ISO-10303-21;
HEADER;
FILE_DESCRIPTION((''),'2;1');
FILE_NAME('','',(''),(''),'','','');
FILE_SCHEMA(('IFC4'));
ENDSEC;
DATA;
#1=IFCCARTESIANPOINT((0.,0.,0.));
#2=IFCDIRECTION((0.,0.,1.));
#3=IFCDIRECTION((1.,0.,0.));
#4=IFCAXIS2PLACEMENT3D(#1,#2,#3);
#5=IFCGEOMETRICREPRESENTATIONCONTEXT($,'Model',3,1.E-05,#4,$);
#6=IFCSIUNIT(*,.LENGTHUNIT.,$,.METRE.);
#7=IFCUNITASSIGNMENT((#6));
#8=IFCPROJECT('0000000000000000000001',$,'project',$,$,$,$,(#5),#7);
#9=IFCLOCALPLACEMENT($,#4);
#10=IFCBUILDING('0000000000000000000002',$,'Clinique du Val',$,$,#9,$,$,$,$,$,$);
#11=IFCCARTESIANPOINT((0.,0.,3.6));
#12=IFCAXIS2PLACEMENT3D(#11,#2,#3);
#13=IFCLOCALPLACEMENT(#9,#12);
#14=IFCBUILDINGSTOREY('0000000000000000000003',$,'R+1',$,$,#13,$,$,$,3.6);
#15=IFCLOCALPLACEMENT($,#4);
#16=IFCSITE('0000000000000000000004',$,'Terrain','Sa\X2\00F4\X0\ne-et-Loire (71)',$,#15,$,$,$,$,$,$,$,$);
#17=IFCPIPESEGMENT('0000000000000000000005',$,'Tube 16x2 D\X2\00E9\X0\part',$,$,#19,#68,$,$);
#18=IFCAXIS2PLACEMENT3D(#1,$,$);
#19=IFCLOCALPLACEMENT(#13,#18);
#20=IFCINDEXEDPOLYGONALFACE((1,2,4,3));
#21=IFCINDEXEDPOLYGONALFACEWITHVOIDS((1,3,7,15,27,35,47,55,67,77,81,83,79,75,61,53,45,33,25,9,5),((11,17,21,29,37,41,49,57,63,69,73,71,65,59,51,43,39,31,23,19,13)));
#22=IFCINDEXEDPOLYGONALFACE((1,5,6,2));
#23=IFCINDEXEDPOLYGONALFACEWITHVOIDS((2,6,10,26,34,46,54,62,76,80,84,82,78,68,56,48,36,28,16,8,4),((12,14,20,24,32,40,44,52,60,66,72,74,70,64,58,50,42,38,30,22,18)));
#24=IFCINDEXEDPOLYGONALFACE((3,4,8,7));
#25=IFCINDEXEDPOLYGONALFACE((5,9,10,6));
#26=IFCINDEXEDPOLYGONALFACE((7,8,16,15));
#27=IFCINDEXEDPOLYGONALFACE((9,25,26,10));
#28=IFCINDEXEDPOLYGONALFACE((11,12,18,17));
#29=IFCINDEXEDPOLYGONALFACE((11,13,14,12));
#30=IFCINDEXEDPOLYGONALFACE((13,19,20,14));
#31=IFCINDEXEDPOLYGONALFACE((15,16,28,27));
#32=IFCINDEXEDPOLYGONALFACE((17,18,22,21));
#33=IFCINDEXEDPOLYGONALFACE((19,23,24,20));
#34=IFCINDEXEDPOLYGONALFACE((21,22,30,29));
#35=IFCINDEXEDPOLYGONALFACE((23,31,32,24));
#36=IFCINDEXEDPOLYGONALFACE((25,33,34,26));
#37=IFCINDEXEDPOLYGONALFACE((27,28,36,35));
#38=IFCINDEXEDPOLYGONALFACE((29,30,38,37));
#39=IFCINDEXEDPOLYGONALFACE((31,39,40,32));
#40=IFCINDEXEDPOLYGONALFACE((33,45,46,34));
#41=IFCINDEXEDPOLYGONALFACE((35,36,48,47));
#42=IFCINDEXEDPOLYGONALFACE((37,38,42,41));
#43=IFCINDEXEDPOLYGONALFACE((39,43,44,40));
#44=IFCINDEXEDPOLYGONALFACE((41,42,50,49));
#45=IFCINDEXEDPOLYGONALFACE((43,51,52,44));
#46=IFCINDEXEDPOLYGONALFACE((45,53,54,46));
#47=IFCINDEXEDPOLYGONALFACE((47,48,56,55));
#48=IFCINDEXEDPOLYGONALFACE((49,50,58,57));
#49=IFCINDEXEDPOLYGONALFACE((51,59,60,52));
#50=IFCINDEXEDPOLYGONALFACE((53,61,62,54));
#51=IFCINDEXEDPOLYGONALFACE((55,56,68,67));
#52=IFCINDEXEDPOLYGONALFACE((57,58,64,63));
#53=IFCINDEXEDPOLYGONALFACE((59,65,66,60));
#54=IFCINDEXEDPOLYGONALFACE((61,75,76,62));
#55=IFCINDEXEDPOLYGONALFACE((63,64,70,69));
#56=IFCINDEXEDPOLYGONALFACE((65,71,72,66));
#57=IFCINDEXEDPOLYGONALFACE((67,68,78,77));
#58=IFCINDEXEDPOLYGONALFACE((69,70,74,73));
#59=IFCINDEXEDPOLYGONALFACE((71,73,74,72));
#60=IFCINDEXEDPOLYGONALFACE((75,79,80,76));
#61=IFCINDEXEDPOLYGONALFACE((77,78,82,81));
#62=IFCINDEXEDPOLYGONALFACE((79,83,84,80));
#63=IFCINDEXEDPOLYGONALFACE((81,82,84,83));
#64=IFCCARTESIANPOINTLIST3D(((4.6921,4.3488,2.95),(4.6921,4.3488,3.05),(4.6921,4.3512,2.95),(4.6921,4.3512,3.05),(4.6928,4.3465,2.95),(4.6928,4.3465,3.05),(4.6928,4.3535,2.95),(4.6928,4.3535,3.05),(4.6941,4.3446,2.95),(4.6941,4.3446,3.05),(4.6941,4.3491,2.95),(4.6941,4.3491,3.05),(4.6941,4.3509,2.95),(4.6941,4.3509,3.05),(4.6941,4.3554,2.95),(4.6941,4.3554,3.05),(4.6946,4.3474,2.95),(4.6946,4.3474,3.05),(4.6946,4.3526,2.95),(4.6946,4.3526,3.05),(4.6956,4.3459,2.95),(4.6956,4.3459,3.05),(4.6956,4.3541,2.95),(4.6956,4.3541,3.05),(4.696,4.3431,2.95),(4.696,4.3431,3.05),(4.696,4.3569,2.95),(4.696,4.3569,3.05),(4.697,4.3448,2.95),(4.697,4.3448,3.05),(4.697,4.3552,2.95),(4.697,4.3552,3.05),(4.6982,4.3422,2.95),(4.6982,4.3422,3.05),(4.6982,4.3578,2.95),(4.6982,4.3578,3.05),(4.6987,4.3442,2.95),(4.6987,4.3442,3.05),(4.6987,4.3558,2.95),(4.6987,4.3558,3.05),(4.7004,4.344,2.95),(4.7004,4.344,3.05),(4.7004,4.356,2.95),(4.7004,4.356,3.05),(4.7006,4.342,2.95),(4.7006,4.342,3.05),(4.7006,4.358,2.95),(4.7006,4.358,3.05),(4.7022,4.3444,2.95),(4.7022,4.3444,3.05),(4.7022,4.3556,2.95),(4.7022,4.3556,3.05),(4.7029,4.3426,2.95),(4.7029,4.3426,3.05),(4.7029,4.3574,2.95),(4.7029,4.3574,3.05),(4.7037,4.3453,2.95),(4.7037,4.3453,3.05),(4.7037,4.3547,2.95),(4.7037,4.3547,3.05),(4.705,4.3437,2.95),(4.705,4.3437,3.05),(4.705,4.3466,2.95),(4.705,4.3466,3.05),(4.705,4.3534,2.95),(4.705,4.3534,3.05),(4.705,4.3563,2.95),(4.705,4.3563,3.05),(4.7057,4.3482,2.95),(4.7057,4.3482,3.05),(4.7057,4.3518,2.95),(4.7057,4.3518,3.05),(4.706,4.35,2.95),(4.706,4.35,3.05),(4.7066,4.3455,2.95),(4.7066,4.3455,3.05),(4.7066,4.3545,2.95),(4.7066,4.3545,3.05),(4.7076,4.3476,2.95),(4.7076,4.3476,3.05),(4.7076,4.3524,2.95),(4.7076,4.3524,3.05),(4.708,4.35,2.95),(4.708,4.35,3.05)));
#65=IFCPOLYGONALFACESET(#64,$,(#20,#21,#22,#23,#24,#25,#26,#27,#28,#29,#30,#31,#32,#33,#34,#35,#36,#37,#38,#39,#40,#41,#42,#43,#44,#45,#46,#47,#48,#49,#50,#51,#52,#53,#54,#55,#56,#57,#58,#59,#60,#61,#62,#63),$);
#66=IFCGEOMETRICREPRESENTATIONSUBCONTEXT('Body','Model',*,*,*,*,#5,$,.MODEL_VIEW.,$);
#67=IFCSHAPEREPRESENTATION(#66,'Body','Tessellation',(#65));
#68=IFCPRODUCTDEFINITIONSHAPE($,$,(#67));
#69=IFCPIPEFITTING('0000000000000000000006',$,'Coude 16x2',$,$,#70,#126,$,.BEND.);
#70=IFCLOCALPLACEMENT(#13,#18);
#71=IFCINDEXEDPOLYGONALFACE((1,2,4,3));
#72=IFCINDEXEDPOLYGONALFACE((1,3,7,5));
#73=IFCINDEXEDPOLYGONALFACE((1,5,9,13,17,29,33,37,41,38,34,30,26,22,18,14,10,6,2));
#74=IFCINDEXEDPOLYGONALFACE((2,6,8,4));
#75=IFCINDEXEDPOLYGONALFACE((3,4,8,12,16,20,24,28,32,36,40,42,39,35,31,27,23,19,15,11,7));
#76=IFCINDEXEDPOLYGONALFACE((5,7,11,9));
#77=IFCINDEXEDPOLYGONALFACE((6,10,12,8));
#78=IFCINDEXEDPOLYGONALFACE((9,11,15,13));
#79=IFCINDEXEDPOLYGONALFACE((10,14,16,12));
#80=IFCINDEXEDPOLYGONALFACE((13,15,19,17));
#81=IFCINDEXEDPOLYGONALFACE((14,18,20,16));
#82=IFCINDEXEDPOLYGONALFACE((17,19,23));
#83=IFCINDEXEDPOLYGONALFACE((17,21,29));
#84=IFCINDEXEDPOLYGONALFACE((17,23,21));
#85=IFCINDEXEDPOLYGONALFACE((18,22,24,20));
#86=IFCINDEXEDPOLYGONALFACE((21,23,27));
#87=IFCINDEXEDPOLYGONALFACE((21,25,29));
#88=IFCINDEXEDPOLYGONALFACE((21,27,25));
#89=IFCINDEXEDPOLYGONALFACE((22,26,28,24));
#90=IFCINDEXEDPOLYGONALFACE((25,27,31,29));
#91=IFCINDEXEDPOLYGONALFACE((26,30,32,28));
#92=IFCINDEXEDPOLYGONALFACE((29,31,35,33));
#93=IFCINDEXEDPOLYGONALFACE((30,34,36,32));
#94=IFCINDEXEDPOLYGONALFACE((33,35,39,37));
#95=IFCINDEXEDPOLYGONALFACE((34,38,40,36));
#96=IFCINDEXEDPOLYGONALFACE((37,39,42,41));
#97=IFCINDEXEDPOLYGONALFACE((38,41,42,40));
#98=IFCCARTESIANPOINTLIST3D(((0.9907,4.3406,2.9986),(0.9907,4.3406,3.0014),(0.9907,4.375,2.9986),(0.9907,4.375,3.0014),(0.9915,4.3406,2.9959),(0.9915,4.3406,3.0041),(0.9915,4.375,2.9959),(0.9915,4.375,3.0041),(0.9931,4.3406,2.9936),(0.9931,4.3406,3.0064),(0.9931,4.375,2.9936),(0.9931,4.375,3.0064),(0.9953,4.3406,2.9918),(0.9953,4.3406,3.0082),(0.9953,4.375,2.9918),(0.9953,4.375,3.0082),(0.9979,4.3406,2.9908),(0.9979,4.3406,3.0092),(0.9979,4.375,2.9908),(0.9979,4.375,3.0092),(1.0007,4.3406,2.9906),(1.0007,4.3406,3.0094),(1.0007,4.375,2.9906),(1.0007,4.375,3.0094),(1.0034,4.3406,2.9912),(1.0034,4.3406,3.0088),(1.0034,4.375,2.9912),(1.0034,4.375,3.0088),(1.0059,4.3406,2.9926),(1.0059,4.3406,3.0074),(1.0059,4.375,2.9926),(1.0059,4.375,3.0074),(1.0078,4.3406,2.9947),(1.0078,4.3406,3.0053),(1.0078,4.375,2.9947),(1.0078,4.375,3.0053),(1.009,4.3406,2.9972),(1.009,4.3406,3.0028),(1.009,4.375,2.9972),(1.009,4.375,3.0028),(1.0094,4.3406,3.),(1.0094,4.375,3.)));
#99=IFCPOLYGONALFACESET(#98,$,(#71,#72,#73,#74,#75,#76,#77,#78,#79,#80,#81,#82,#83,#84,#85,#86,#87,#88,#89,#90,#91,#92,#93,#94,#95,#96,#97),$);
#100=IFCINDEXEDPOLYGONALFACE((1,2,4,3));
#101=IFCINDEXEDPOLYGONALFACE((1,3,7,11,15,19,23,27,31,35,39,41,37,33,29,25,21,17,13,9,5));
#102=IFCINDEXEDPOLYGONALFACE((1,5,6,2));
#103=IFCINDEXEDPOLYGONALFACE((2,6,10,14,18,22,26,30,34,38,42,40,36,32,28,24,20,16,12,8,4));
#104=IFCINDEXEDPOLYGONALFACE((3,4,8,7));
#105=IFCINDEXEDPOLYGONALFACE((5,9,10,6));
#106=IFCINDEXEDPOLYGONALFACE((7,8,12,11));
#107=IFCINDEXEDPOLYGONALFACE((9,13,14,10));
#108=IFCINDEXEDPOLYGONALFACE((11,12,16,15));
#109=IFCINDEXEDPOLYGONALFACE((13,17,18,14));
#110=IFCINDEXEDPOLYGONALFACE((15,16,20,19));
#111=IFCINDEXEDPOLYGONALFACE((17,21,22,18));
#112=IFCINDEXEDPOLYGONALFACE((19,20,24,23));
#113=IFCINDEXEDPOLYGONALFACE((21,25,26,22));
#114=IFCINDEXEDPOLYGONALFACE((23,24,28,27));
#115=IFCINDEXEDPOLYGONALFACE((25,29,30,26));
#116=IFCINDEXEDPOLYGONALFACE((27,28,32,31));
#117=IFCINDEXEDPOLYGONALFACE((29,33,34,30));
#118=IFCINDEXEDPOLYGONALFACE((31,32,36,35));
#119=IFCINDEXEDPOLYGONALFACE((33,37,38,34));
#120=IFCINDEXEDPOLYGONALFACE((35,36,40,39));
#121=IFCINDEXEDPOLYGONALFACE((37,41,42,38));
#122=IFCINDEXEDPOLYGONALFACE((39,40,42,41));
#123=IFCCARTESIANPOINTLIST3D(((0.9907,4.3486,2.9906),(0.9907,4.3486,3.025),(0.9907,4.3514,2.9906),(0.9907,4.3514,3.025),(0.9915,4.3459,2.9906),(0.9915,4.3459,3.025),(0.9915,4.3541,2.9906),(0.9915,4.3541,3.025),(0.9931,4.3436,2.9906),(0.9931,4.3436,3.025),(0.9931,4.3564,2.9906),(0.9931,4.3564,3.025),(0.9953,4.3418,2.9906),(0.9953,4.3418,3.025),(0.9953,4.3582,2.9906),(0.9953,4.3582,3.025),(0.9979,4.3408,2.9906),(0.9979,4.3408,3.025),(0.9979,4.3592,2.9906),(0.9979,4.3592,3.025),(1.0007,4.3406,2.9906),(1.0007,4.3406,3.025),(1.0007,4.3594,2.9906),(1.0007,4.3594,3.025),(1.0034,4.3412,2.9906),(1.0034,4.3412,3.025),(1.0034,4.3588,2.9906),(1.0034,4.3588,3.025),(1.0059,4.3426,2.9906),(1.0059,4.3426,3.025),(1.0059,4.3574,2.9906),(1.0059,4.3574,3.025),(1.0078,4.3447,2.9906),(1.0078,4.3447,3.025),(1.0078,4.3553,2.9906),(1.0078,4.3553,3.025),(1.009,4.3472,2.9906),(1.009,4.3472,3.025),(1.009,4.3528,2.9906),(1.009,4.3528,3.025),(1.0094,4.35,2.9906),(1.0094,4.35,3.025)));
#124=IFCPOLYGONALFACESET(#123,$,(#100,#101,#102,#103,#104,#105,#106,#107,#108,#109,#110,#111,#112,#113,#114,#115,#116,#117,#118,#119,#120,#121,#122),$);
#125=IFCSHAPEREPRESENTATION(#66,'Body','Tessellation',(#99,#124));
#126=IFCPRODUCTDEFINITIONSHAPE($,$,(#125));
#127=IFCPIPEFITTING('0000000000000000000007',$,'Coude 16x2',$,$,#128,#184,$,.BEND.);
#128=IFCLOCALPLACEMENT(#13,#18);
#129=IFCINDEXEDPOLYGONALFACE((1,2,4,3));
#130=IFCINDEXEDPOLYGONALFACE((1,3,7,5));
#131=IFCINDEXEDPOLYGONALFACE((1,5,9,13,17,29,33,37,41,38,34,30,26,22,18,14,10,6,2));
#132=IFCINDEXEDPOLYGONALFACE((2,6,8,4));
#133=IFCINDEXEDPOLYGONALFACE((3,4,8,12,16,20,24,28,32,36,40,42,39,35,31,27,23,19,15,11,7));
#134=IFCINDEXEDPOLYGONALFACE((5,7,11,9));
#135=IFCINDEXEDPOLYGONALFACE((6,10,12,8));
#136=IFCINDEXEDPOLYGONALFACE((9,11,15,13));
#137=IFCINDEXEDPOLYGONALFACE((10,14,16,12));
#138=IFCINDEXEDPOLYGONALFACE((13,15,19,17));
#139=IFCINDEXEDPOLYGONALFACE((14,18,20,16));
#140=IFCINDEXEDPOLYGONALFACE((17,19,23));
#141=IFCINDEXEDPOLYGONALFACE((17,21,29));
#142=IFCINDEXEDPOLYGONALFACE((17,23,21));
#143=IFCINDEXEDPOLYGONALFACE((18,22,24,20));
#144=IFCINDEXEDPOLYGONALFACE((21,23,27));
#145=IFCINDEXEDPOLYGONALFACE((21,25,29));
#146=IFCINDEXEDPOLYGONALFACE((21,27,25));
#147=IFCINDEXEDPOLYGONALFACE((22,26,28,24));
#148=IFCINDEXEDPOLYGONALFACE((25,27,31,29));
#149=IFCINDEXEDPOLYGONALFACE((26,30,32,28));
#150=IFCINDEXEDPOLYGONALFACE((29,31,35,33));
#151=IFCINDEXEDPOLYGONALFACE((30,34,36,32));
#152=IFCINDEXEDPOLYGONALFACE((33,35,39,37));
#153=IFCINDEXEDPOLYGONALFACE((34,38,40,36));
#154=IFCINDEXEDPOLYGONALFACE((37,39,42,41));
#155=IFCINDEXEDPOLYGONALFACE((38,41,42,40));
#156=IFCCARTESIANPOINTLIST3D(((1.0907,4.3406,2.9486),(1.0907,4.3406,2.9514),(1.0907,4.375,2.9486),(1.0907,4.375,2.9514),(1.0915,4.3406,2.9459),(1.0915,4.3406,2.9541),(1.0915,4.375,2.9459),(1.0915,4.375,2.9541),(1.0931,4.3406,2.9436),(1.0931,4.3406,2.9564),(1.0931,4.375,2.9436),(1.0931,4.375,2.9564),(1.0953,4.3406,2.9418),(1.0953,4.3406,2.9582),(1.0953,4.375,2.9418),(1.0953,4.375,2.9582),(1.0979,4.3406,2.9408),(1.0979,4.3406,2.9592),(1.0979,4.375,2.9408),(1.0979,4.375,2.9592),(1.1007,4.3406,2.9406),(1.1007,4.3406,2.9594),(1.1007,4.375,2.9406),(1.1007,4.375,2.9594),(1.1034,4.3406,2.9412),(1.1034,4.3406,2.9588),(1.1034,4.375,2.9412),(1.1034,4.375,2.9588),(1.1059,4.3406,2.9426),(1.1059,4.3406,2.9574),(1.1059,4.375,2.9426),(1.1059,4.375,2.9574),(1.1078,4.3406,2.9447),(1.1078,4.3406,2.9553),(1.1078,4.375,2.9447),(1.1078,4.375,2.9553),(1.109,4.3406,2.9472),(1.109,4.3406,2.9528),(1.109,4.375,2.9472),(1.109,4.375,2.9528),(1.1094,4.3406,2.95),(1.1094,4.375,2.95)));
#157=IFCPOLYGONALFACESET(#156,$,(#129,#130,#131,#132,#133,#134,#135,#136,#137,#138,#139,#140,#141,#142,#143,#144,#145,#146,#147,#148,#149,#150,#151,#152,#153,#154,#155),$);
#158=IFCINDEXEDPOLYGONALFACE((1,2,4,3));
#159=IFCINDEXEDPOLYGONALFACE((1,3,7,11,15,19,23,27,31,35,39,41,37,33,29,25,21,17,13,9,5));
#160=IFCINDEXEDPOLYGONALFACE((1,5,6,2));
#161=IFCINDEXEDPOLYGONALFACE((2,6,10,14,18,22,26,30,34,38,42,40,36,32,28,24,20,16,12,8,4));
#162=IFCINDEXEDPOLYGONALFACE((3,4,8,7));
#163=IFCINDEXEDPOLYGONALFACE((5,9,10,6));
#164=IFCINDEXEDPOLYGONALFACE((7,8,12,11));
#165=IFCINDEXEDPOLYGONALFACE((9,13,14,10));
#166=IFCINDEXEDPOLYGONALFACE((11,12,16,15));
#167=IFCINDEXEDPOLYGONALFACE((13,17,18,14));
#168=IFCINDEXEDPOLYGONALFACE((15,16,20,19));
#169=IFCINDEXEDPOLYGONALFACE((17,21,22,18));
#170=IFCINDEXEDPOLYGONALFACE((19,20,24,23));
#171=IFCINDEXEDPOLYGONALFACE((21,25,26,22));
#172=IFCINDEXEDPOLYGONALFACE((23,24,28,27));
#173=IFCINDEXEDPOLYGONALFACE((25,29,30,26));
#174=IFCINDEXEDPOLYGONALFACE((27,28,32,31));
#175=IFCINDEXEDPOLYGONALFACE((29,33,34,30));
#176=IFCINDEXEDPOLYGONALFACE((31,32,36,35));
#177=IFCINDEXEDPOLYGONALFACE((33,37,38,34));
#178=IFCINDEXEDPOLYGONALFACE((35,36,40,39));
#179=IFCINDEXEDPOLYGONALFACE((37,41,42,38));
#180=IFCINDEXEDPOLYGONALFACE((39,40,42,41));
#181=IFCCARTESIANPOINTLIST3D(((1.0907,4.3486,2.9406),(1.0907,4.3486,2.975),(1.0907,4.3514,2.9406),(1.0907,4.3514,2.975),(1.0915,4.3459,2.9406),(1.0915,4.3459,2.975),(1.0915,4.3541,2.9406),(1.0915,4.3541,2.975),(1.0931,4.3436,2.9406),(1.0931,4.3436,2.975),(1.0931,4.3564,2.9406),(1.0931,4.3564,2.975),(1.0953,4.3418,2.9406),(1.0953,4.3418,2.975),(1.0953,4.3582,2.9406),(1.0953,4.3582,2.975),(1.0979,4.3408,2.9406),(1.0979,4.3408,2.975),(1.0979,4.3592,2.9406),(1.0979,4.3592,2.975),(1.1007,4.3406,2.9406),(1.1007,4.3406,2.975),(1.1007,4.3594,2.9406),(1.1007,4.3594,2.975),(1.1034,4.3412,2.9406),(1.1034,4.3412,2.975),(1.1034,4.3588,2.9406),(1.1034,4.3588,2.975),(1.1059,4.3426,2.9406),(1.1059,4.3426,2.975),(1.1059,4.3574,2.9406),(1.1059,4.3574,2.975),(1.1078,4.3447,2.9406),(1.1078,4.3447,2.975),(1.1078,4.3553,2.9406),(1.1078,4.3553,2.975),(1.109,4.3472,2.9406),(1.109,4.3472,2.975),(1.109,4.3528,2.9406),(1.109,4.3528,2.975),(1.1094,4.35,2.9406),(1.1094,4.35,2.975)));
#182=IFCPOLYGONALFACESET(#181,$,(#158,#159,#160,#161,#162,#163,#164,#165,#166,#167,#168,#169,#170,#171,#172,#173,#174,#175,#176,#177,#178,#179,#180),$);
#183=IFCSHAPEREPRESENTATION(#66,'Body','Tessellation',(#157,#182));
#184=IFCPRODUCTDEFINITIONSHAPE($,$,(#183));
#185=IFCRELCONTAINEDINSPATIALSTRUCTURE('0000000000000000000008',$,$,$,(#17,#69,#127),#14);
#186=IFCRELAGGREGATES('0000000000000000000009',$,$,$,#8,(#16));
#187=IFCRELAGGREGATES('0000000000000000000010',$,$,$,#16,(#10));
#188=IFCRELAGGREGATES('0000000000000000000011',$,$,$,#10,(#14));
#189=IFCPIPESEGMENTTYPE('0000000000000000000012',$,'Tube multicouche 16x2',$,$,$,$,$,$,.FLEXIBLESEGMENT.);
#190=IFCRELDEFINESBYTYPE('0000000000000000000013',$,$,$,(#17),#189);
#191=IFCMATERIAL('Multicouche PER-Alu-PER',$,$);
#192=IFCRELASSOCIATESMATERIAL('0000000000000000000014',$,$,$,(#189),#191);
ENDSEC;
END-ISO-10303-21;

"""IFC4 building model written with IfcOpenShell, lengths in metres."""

from ifc_helpers import new_model, si_unit, frame, origin_with_axes, place, context, subcontext, project, spatial, circle, hollow_circle, extrude, material, type_object, element, save


model = new_model("IFC4")

# Units and contexts
model_context = context("Model", 3, precision=1e-05, world=origin_with_axes())
body_context = subcontext(model_context, "Body", "Model", "MODEL_VIEW")
ifc_project = project(units=[si_unit("LENGTHUNIT", "METRE")], contexts=[model_context])

# Site, building, storey
site_placement = place(None, origin_with_axes())
site = spatial("IfcSite", under=ifc_project, at=site_placement, Name="Terrain", Description="Saône-et-Loire (71)")
building_placement = place(None, origin_with_axes())
building = spatial("IfcBuilding", under=site, at=building_placement, Name="Clinique du Val")
storey_placement = place(building_placement, frame((0.0, 0.0, 3.6), z_axis=(0.0, 0.0, 1.0), x_axis=(1.0, 0.0, 0.0)))
storey = spatial("IfcBuildingStorey", under=building, at=storey_placement, Name="R+1", Elevation=3.6)

# Pipe segment
ifc_material_1 = material(Name="Multicouche PER-Alu-PER")
pipe_segment_type = type_object("IfcPipeSegmentType", Name="Tube multicouche 16x2", PredefinedType="FLEXIBLESEGMENT", material=ifc_material_1)
pipe_segment_1_placement = place(storey_placement, frame((4.7, 4.35, 2.95), z_axis=(0.0, 0.0, 1.0), x_axis=(1.0, 0.0, 0.0)))
element("IfcPipeSegment", 1, at=pipe_segment_1_placement, inside=storey, type_object=pipe_segment_type, Name="Tube 16x2 Départ", context=body_context, shape_type="SweptSolid", body=[
    extrude(hollow_circle(Radius=0.008, WallThickness=0.002), origin_with_axes(), (0.0, 0.0, 1.0), 0.1),
])

# Pipe fittings
for number, where, z_axis, x_axis, name in (
    (2, (1.0, 4.35, 3.0), (0.0, 0.0, 1.0), (1.0, 0.0, 0.0), "Coude 16x2"),
    (3, (1.1, 4.35, 2.95), (0.0, 0.0, 1.0), (1.0, 0.0, 0.0), "Coude 16x2"),
):
    element("IfcPipeFitting", number, at=place(storey_placement, frame(where, z_axis=z_axis, x_axis=x_axis)), inside=storey, Name=name, PredefinedType="BEND", context=body_context, shape_type="SweptSolid", body=[
        extrude(circle(Radius=0.0094), frame((0.0, -0.0094, 0.0), z_axis=(0.0, 1.0, 0.0), x_axis=(1.0, 0.0, 0.0)), (0.0, 0.0, 1.0), 0.0344),
        extrude(circle(Radius=0.0094), frame((0.0, 0.0, -0.0094), z_axis=(0.0, 0.0, 1.0), x_axis=(1.0, 0.0, 0.0)), (0.0, 0.0, 1.0), 0.0344),
    ])

save(model, "model.ifc")
